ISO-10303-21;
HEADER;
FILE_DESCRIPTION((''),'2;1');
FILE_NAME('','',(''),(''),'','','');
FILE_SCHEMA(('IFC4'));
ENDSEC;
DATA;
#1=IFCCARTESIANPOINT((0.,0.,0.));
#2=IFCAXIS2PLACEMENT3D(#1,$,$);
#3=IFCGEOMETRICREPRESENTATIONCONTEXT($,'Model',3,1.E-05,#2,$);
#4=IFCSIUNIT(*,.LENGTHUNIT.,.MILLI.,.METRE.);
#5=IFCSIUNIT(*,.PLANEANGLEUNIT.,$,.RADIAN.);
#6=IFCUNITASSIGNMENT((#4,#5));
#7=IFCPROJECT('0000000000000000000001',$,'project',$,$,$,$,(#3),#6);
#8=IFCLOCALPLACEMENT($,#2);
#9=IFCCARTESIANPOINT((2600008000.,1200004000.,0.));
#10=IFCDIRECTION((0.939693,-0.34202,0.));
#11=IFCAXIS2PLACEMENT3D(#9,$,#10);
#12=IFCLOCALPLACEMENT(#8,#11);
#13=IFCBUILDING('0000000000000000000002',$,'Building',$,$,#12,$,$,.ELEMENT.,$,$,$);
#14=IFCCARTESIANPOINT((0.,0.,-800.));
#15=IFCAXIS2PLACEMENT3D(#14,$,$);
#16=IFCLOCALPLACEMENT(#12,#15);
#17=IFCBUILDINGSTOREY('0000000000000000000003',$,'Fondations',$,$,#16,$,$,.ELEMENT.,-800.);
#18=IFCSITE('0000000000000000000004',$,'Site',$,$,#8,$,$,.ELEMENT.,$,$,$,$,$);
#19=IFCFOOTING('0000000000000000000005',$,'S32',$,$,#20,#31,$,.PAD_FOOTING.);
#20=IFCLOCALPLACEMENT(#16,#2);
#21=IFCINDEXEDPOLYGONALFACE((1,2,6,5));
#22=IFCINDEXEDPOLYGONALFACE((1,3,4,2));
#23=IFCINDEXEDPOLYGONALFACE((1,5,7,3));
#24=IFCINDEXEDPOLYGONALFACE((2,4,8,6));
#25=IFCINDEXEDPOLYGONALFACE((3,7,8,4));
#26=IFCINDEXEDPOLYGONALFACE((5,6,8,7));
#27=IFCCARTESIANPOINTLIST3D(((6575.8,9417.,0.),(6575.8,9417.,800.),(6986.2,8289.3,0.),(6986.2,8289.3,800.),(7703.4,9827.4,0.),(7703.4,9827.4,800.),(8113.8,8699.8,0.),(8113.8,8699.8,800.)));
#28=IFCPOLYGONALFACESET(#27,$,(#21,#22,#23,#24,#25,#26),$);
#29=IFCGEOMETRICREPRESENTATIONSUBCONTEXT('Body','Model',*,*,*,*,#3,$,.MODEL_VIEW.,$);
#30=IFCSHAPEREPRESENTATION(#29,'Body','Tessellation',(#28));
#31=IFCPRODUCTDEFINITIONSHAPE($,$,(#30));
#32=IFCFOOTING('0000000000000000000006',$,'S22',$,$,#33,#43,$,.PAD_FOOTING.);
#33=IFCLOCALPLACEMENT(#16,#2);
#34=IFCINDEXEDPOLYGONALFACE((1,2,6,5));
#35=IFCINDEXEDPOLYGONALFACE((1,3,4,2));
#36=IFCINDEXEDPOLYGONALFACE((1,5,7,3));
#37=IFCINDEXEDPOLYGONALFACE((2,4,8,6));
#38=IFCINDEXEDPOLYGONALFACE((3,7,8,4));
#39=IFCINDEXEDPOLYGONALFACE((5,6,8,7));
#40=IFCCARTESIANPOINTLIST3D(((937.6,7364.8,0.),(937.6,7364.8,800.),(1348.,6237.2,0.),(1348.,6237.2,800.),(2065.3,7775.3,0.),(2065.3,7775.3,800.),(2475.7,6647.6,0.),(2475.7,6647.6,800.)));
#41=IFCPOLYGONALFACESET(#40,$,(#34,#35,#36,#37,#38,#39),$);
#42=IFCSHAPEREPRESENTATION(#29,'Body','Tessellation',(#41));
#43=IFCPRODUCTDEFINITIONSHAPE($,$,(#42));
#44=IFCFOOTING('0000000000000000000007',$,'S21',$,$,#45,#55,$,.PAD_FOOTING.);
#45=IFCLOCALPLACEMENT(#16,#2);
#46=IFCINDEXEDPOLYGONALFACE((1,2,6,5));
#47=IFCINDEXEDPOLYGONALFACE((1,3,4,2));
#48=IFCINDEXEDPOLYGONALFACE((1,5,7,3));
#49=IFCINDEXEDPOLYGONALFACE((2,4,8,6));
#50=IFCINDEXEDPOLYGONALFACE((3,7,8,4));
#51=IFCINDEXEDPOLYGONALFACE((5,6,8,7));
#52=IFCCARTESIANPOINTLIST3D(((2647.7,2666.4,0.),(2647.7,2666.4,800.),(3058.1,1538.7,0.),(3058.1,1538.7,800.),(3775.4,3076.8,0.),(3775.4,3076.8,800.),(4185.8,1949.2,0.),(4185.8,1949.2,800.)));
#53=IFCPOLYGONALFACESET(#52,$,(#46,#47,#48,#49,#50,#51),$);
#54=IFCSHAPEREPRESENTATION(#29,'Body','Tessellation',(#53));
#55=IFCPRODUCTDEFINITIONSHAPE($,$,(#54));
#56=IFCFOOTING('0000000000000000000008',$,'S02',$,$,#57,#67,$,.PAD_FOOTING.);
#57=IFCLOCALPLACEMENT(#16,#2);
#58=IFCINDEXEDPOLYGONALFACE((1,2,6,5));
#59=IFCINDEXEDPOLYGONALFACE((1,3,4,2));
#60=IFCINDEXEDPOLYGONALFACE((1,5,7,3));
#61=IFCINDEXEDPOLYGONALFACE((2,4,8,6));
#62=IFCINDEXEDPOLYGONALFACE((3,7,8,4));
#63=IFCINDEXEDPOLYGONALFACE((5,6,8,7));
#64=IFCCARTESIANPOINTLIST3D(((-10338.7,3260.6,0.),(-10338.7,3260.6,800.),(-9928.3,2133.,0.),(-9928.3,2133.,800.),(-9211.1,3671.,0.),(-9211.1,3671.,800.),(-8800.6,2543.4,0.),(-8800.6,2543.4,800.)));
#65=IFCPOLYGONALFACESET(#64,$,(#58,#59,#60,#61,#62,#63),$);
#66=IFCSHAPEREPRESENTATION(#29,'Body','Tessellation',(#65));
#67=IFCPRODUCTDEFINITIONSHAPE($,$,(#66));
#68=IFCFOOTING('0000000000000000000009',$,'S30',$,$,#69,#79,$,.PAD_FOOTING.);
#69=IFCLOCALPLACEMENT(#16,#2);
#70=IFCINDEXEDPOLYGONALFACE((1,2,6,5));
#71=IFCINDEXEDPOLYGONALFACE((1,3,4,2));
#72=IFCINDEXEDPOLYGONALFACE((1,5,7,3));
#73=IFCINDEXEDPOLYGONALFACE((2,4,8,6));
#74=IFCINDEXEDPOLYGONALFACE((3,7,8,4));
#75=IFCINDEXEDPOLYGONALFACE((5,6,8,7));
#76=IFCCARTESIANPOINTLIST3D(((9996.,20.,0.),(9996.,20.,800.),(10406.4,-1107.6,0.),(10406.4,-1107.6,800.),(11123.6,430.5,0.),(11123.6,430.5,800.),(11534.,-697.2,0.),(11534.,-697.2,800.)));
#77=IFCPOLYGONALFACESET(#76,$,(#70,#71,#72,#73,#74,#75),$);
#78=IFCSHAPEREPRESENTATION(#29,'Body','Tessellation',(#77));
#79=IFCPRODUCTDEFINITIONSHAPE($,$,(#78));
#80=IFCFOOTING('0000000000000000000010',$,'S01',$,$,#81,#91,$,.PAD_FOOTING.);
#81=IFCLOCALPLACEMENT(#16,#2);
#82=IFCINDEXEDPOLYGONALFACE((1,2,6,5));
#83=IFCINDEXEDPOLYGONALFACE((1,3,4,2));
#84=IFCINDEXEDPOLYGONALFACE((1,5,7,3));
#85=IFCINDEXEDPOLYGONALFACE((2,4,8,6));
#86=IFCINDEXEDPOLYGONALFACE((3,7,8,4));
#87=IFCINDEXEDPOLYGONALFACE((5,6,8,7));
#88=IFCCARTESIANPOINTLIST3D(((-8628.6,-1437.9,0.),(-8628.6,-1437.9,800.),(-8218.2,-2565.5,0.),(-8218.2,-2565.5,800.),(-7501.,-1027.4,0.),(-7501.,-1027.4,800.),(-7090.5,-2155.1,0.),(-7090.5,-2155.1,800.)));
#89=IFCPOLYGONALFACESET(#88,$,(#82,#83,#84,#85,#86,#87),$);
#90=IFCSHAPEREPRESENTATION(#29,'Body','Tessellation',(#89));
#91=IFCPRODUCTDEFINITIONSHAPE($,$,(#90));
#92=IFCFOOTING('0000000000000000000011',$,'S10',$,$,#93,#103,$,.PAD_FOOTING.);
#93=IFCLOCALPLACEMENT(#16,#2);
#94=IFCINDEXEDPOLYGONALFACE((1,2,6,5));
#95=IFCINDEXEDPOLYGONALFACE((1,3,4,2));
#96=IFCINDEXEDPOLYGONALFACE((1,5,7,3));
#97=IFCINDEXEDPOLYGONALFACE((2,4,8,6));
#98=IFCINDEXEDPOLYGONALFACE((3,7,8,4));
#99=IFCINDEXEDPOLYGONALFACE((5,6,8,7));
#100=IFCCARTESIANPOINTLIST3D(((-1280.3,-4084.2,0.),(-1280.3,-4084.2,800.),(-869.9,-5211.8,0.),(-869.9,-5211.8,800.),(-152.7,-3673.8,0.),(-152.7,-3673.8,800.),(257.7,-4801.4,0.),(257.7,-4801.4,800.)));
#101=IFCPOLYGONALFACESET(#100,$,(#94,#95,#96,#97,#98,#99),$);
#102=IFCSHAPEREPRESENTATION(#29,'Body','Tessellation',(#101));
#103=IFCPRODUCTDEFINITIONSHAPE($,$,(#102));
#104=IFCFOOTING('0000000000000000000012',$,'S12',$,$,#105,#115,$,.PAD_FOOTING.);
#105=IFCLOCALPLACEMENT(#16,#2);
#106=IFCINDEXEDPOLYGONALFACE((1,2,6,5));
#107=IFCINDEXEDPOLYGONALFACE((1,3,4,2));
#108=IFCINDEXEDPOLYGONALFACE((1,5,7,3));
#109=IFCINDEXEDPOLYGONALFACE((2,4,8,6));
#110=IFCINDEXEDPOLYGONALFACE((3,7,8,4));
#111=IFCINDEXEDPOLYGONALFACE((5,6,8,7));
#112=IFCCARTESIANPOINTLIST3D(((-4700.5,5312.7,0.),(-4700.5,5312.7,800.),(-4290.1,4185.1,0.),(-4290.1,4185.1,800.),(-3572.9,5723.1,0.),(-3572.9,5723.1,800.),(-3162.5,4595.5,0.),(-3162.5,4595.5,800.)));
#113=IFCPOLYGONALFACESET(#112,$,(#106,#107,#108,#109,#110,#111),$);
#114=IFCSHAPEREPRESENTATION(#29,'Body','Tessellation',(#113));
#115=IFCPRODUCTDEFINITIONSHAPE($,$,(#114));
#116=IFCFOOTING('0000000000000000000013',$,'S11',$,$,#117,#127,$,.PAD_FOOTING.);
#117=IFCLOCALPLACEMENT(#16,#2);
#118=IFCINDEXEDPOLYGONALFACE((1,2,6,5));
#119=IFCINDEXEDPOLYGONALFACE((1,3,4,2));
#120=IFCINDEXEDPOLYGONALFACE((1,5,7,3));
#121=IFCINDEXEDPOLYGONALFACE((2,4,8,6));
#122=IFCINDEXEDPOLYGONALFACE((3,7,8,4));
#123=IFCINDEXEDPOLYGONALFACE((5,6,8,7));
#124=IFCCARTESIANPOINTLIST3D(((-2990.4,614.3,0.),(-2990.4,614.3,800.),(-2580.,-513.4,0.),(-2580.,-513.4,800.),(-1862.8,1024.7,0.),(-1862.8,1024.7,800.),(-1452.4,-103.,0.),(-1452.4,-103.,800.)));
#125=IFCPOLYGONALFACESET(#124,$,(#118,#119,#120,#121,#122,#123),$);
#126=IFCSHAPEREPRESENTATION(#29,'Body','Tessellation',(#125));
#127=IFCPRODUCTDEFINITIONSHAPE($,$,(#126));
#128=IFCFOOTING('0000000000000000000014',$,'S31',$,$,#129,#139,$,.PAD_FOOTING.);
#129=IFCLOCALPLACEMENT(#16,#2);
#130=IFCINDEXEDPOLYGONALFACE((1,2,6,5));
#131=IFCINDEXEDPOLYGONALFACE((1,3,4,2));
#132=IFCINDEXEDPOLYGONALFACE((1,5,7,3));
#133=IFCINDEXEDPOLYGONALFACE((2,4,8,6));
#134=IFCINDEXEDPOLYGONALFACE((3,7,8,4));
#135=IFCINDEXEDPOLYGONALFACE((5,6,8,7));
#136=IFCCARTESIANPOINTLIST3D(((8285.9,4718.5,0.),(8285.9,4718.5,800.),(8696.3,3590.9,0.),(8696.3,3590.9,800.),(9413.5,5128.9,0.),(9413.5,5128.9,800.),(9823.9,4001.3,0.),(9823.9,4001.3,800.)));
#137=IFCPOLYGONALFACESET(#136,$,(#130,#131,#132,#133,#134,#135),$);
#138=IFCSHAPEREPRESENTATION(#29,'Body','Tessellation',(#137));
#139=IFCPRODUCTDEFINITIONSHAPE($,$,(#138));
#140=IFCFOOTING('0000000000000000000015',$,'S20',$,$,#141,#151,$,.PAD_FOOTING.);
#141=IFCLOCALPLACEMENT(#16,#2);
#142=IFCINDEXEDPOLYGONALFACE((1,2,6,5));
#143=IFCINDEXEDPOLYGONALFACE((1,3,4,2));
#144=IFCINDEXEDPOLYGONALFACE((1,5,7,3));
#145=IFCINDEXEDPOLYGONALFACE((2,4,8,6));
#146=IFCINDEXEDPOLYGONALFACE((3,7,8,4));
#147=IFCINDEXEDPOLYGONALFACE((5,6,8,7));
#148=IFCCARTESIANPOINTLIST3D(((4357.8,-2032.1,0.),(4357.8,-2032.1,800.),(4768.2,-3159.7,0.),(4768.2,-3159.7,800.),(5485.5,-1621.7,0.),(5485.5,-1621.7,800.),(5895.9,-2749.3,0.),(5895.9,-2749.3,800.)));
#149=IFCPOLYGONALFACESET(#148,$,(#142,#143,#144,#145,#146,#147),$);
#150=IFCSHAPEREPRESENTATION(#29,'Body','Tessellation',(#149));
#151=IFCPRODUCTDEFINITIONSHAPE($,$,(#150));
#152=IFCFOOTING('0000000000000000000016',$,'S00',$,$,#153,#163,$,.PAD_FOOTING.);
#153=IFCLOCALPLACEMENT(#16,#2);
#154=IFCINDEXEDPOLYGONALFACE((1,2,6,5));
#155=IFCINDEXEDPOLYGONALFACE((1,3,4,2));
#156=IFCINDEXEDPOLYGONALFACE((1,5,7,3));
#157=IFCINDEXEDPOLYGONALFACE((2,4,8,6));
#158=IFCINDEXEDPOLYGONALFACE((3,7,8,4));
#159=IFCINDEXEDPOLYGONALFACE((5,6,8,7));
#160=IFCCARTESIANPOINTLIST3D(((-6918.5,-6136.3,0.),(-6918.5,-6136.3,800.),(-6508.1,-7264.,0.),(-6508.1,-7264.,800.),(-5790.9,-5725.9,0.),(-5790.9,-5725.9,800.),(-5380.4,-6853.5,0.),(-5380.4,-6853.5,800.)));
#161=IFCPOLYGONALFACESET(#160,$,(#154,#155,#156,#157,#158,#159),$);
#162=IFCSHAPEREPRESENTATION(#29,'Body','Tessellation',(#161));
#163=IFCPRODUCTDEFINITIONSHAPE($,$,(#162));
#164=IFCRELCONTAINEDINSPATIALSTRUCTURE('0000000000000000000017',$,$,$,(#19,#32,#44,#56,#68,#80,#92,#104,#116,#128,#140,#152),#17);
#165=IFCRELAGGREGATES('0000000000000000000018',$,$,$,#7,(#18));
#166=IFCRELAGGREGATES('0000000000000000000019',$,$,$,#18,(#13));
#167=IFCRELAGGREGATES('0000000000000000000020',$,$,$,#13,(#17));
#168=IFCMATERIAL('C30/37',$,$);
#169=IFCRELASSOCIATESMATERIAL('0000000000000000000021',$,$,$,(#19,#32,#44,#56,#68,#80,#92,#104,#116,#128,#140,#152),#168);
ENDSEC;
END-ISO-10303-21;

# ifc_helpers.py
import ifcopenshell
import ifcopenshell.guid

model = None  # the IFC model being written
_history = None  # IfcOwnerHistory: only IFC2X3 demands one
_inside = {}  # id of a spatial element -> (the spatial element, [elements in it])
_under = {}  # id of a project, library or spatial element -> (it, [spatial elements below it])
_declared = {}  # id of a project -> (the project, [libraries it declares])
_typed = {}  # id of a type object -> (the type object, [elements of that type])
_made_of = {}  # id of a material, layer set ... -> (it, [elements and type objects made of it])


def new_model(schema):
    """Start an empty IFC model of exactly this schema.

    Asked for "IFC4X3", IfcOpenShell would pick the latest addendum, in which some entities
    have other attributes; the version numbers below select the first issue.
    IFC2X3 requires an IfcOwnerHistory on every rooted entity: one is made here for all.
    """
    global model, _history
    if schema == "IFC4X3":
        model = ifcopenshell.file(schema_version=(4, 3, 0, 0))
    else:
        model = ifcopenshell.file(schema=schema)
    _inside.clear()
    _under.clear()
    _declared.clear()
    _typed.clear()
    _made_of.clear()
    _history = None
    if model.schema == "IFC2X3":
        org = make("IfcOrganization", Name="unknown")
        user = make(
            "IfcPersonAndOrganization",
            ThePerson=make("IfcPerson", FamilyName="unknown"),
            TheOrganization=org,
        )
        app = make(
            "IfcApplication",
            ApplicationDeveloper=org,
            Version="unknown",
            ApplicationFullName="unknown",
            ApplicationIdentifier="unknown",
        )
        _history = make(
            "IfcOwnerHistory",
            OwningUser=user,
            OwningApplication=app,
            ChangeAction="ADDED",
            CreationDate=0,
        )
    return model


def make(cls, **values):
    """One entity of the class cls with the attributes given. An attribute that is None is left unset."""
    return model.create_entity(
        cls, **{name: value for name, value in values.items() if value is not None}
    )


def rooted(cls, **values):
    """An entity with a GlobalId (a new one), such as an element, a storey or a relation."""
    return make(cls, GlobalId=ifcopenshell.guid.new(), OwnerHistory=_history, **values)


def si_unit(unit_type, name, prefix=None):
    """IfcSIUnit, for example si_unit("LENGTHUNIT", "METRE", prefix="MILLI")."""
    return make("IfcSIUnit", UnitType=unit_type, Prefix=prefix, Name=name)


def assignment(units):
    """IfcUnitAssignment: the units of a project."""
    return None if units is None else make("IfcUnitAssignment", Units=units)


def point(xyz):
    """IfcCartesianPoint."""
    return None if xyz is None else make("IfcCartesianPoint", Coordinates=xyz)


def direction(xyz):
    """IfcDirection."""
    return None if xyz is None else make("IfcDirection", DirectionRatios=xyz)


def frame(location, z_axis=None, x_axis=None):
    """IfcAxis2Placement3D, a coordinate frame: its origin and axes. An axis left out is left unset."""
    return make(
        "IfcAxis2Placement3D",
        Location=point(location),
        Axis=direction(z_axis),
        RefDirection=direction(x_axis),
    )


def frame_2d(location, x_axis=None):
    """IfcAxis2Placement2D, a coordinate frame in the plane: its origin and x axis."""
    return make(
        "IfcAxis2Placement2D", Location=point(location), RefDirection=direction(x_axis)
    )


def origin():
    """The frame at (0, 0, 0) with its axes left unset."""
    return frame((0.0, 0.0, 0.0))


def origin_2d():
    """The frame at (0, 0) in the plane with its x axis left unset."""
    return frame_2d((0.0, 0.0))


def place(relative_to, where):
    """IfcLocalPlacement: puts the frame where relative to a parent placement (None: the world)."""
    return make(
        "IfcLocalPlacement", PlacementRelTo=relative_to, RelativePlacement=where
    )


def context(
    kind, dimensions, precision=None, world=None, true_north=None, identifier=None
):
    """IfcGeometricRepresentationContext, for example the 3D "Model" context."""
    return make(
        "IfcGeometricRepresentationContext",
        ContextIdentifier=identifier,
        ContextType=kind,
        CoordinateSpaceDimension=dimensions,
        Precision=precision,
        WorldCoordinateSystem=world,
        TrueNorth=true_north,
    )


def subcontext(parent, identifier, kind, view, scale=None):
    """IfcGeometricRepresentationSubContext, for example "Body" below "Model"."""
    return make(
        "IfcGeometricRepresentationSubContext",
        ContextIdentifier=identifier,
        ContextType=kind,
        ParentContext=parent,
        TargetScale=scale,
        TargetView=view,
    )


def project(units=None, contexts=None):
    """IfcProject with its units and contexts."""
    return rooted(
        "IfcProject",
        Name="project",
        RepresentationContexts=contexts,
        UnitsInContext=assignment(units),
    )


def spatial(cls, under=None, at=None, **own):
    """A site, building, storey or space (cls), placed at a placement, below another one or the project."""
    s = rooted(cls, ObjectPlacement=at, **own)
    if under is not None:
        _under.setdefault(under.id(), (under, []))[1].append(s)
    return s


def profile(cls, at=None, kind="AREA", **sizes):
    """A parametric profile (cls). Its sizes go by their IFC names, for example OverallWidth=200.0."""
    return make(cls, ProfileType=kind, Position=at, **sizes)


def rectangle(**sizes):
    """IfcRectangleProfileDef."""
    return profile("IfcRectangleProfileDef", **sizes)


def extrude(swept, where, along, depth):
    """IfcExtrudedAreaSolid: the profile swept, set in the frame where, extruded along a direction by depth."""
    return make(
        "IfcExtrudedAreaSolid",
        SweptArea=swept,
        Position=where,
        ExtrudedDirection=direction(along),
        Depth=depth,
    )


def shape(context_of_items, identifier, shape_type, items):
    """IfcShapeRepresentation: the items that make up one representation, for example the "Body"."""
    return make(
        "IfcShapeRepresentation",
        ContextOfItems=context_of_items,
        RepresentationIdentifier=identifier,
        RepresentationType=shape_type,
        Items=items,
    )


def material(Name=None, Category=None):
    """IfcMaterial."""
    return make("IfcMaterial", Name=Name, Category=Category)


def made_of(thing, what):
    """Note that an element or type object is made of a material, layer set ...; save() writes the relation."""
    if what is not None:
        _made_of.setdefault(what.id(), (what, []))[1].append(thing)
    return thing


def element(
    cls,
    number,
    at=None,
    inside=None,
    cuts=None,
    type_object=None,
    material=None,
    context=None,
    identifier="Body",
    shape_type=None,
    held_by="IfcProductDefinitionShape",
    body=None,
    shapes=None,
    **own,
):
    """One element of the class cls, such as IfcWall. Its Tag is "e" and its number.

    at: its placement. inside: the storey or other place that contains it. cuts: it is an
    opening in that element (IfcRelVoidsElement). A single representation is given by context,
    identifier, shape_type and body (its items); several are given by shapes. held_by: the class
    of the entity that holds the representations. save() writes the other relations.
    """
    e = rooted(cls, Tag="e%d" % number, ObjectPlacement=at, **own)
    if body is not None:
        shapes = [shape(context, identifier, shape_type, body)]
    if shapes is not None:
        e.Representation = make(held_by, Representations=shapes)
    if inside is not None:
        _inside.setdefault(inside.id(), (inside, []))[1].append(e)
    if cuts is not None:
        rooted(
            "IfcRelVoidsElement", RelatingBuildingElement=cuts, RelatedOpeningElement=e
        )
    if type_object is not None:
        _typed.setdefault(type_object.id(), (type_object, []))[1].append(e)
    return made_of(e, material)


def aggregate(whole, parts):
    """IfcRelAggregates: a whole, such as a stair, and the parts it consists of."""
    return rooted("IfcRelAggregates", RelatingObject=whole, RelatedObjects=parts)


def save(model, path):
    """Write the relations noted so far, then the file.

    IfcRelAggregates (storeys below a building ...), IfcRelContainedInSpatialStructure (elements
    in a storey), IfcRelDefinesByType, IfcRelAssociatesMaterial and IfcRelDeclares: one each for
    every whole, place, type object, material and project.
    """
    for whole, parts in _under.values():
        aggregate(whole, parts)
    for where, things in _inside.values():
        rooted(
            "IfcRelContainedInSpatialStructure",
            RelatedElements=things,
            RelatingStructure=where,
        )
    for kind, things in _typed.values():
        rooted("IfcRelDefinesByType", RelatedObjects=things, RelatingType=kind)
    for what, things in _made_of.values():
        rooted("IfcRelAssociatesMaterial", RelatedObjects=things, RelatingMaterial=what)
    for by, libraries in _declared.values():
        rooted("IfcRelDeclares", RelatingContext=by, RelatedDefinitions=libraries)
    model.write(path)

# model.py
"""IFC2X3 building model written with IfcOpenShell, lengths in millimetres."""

from ifc_helpers import new_model, si_unit, frame, origin, origin_2d, place, context, subcontext, project, spatial, rectangle, extrude, material, element, save


model = new_model("IFC2X3")

# Units and contexts
model_context = context("Model", 3, precision=1e-05, world=origin())
body_context = subcontext(model_context, "Body", "Model", "MODEL_VIEW")
ifc_project = project(units=[si_unit("LENGTHUNIT", "METRE", prefix="MILLI"), si_unit("PLANEANGLEUNIT", "RADIAN")], contexts=[model_context])

# Site, building, storey
site_placement = place(None, origin())
site = spatial("IfcSite", under=ifc_project, at=site_placement, Name="Site", CompositionType="ELEMENT")
building_placement = place(site_placement, frame((2600008000.0, 1200004000.0, 0.0), x_axis=(0.939693, -0.34202, 0.0)))
building = spatial("IfcBuilding", under=site, at=building_placement, Name="Building", CompositionType="ELEMENT")
storey_placement = place(building_placement, frame((0.0, 0.0, -800.0)))
storey = spatial("IfcBuildingStorey", under=building, at=storey_placement, Name="Fondations", CompositionType="ELEMENT", Elevation=-800.0)

# Footings
ifc_material = material(Name="C30/37")
for number, where, z_axis, x_axis, name in (
    (1, (7344.8, 9058.4, 0.0), (0.0, 0.0, 1.0), (0.939693, 0.34202, 0.0), "S32"),
    (2, (1706.6, 7006.2, 0.0), (0.0, 0.0, 1.0), (0.939693, 0.34202, 0.0), "S22"),
    (3, (3416.8, 2307.8, 0.0), (0.0, 0.0, 1.0), (0.939693, 0.34202, 0.0), "S21"),
    (4, (-9569.7, 2902.0, 0.0), (0.0, 0.0, 1.0), (0.939693, 0.34202, 0.0), "S02"),
    (5, (10765.0, -338.6, 0.0), (0.0, 0.0, 1.0), (0.939693, 0.34202, 0.0), "S30"),
    (6, (-7859.6, -1796.5, 0.0), (0.0, 0.0, 1.0), (0.939693, 0.34202, 0.0), "S01"),
    (7, (-511.3, -4442.8, 0.0), (0.0, 0.0, 1.0), (0.939693, 0.34202, 0.0), "S10"),
    (8, (-3931.5, 4954.1, 0.0), (0.0, 0.0, 1.0), (0.939693, 0.34202, 0.0), "S12"),
    (9, (-2221.4, 255.7, 0.0), (0.0, 0.0, 1.0), (0.939693, 0.34202, 0.0), "S11"),
    (10, (9054.9, 4359.9, 0.0), (0.0, 0.0, 1.0), (0.939693, 0.34202, 0.0), "S31"),
    (11, (5126.9, -2390.7, 0.0), (0.0, 0.0, 1.0), (0.939693, 0.34202, 0.0), "S20"),
    (12, (-6149.5, -6494.9, 0.0), (0.0, 0.0, 1.0), (0.939693, 0.34202, 0.0), "S00"),
):
    element("IfcFooting", number, at=place(storey_placement, frame(where, z_axis=z_axis, x_axis=x_axis)), inside=storey, material=ifc_material, Name=name, PredefinedType="PAD_FOOTING", context=body_context, shape_type="SweptSolid", body=[
        extrude(rectangle(XDim=1200.0, YDim=1200.0, at=origin_2d()), origin(), (0.0, 0.0, 1.0), 800.0),
    ])

save(model, "model.ifc")
